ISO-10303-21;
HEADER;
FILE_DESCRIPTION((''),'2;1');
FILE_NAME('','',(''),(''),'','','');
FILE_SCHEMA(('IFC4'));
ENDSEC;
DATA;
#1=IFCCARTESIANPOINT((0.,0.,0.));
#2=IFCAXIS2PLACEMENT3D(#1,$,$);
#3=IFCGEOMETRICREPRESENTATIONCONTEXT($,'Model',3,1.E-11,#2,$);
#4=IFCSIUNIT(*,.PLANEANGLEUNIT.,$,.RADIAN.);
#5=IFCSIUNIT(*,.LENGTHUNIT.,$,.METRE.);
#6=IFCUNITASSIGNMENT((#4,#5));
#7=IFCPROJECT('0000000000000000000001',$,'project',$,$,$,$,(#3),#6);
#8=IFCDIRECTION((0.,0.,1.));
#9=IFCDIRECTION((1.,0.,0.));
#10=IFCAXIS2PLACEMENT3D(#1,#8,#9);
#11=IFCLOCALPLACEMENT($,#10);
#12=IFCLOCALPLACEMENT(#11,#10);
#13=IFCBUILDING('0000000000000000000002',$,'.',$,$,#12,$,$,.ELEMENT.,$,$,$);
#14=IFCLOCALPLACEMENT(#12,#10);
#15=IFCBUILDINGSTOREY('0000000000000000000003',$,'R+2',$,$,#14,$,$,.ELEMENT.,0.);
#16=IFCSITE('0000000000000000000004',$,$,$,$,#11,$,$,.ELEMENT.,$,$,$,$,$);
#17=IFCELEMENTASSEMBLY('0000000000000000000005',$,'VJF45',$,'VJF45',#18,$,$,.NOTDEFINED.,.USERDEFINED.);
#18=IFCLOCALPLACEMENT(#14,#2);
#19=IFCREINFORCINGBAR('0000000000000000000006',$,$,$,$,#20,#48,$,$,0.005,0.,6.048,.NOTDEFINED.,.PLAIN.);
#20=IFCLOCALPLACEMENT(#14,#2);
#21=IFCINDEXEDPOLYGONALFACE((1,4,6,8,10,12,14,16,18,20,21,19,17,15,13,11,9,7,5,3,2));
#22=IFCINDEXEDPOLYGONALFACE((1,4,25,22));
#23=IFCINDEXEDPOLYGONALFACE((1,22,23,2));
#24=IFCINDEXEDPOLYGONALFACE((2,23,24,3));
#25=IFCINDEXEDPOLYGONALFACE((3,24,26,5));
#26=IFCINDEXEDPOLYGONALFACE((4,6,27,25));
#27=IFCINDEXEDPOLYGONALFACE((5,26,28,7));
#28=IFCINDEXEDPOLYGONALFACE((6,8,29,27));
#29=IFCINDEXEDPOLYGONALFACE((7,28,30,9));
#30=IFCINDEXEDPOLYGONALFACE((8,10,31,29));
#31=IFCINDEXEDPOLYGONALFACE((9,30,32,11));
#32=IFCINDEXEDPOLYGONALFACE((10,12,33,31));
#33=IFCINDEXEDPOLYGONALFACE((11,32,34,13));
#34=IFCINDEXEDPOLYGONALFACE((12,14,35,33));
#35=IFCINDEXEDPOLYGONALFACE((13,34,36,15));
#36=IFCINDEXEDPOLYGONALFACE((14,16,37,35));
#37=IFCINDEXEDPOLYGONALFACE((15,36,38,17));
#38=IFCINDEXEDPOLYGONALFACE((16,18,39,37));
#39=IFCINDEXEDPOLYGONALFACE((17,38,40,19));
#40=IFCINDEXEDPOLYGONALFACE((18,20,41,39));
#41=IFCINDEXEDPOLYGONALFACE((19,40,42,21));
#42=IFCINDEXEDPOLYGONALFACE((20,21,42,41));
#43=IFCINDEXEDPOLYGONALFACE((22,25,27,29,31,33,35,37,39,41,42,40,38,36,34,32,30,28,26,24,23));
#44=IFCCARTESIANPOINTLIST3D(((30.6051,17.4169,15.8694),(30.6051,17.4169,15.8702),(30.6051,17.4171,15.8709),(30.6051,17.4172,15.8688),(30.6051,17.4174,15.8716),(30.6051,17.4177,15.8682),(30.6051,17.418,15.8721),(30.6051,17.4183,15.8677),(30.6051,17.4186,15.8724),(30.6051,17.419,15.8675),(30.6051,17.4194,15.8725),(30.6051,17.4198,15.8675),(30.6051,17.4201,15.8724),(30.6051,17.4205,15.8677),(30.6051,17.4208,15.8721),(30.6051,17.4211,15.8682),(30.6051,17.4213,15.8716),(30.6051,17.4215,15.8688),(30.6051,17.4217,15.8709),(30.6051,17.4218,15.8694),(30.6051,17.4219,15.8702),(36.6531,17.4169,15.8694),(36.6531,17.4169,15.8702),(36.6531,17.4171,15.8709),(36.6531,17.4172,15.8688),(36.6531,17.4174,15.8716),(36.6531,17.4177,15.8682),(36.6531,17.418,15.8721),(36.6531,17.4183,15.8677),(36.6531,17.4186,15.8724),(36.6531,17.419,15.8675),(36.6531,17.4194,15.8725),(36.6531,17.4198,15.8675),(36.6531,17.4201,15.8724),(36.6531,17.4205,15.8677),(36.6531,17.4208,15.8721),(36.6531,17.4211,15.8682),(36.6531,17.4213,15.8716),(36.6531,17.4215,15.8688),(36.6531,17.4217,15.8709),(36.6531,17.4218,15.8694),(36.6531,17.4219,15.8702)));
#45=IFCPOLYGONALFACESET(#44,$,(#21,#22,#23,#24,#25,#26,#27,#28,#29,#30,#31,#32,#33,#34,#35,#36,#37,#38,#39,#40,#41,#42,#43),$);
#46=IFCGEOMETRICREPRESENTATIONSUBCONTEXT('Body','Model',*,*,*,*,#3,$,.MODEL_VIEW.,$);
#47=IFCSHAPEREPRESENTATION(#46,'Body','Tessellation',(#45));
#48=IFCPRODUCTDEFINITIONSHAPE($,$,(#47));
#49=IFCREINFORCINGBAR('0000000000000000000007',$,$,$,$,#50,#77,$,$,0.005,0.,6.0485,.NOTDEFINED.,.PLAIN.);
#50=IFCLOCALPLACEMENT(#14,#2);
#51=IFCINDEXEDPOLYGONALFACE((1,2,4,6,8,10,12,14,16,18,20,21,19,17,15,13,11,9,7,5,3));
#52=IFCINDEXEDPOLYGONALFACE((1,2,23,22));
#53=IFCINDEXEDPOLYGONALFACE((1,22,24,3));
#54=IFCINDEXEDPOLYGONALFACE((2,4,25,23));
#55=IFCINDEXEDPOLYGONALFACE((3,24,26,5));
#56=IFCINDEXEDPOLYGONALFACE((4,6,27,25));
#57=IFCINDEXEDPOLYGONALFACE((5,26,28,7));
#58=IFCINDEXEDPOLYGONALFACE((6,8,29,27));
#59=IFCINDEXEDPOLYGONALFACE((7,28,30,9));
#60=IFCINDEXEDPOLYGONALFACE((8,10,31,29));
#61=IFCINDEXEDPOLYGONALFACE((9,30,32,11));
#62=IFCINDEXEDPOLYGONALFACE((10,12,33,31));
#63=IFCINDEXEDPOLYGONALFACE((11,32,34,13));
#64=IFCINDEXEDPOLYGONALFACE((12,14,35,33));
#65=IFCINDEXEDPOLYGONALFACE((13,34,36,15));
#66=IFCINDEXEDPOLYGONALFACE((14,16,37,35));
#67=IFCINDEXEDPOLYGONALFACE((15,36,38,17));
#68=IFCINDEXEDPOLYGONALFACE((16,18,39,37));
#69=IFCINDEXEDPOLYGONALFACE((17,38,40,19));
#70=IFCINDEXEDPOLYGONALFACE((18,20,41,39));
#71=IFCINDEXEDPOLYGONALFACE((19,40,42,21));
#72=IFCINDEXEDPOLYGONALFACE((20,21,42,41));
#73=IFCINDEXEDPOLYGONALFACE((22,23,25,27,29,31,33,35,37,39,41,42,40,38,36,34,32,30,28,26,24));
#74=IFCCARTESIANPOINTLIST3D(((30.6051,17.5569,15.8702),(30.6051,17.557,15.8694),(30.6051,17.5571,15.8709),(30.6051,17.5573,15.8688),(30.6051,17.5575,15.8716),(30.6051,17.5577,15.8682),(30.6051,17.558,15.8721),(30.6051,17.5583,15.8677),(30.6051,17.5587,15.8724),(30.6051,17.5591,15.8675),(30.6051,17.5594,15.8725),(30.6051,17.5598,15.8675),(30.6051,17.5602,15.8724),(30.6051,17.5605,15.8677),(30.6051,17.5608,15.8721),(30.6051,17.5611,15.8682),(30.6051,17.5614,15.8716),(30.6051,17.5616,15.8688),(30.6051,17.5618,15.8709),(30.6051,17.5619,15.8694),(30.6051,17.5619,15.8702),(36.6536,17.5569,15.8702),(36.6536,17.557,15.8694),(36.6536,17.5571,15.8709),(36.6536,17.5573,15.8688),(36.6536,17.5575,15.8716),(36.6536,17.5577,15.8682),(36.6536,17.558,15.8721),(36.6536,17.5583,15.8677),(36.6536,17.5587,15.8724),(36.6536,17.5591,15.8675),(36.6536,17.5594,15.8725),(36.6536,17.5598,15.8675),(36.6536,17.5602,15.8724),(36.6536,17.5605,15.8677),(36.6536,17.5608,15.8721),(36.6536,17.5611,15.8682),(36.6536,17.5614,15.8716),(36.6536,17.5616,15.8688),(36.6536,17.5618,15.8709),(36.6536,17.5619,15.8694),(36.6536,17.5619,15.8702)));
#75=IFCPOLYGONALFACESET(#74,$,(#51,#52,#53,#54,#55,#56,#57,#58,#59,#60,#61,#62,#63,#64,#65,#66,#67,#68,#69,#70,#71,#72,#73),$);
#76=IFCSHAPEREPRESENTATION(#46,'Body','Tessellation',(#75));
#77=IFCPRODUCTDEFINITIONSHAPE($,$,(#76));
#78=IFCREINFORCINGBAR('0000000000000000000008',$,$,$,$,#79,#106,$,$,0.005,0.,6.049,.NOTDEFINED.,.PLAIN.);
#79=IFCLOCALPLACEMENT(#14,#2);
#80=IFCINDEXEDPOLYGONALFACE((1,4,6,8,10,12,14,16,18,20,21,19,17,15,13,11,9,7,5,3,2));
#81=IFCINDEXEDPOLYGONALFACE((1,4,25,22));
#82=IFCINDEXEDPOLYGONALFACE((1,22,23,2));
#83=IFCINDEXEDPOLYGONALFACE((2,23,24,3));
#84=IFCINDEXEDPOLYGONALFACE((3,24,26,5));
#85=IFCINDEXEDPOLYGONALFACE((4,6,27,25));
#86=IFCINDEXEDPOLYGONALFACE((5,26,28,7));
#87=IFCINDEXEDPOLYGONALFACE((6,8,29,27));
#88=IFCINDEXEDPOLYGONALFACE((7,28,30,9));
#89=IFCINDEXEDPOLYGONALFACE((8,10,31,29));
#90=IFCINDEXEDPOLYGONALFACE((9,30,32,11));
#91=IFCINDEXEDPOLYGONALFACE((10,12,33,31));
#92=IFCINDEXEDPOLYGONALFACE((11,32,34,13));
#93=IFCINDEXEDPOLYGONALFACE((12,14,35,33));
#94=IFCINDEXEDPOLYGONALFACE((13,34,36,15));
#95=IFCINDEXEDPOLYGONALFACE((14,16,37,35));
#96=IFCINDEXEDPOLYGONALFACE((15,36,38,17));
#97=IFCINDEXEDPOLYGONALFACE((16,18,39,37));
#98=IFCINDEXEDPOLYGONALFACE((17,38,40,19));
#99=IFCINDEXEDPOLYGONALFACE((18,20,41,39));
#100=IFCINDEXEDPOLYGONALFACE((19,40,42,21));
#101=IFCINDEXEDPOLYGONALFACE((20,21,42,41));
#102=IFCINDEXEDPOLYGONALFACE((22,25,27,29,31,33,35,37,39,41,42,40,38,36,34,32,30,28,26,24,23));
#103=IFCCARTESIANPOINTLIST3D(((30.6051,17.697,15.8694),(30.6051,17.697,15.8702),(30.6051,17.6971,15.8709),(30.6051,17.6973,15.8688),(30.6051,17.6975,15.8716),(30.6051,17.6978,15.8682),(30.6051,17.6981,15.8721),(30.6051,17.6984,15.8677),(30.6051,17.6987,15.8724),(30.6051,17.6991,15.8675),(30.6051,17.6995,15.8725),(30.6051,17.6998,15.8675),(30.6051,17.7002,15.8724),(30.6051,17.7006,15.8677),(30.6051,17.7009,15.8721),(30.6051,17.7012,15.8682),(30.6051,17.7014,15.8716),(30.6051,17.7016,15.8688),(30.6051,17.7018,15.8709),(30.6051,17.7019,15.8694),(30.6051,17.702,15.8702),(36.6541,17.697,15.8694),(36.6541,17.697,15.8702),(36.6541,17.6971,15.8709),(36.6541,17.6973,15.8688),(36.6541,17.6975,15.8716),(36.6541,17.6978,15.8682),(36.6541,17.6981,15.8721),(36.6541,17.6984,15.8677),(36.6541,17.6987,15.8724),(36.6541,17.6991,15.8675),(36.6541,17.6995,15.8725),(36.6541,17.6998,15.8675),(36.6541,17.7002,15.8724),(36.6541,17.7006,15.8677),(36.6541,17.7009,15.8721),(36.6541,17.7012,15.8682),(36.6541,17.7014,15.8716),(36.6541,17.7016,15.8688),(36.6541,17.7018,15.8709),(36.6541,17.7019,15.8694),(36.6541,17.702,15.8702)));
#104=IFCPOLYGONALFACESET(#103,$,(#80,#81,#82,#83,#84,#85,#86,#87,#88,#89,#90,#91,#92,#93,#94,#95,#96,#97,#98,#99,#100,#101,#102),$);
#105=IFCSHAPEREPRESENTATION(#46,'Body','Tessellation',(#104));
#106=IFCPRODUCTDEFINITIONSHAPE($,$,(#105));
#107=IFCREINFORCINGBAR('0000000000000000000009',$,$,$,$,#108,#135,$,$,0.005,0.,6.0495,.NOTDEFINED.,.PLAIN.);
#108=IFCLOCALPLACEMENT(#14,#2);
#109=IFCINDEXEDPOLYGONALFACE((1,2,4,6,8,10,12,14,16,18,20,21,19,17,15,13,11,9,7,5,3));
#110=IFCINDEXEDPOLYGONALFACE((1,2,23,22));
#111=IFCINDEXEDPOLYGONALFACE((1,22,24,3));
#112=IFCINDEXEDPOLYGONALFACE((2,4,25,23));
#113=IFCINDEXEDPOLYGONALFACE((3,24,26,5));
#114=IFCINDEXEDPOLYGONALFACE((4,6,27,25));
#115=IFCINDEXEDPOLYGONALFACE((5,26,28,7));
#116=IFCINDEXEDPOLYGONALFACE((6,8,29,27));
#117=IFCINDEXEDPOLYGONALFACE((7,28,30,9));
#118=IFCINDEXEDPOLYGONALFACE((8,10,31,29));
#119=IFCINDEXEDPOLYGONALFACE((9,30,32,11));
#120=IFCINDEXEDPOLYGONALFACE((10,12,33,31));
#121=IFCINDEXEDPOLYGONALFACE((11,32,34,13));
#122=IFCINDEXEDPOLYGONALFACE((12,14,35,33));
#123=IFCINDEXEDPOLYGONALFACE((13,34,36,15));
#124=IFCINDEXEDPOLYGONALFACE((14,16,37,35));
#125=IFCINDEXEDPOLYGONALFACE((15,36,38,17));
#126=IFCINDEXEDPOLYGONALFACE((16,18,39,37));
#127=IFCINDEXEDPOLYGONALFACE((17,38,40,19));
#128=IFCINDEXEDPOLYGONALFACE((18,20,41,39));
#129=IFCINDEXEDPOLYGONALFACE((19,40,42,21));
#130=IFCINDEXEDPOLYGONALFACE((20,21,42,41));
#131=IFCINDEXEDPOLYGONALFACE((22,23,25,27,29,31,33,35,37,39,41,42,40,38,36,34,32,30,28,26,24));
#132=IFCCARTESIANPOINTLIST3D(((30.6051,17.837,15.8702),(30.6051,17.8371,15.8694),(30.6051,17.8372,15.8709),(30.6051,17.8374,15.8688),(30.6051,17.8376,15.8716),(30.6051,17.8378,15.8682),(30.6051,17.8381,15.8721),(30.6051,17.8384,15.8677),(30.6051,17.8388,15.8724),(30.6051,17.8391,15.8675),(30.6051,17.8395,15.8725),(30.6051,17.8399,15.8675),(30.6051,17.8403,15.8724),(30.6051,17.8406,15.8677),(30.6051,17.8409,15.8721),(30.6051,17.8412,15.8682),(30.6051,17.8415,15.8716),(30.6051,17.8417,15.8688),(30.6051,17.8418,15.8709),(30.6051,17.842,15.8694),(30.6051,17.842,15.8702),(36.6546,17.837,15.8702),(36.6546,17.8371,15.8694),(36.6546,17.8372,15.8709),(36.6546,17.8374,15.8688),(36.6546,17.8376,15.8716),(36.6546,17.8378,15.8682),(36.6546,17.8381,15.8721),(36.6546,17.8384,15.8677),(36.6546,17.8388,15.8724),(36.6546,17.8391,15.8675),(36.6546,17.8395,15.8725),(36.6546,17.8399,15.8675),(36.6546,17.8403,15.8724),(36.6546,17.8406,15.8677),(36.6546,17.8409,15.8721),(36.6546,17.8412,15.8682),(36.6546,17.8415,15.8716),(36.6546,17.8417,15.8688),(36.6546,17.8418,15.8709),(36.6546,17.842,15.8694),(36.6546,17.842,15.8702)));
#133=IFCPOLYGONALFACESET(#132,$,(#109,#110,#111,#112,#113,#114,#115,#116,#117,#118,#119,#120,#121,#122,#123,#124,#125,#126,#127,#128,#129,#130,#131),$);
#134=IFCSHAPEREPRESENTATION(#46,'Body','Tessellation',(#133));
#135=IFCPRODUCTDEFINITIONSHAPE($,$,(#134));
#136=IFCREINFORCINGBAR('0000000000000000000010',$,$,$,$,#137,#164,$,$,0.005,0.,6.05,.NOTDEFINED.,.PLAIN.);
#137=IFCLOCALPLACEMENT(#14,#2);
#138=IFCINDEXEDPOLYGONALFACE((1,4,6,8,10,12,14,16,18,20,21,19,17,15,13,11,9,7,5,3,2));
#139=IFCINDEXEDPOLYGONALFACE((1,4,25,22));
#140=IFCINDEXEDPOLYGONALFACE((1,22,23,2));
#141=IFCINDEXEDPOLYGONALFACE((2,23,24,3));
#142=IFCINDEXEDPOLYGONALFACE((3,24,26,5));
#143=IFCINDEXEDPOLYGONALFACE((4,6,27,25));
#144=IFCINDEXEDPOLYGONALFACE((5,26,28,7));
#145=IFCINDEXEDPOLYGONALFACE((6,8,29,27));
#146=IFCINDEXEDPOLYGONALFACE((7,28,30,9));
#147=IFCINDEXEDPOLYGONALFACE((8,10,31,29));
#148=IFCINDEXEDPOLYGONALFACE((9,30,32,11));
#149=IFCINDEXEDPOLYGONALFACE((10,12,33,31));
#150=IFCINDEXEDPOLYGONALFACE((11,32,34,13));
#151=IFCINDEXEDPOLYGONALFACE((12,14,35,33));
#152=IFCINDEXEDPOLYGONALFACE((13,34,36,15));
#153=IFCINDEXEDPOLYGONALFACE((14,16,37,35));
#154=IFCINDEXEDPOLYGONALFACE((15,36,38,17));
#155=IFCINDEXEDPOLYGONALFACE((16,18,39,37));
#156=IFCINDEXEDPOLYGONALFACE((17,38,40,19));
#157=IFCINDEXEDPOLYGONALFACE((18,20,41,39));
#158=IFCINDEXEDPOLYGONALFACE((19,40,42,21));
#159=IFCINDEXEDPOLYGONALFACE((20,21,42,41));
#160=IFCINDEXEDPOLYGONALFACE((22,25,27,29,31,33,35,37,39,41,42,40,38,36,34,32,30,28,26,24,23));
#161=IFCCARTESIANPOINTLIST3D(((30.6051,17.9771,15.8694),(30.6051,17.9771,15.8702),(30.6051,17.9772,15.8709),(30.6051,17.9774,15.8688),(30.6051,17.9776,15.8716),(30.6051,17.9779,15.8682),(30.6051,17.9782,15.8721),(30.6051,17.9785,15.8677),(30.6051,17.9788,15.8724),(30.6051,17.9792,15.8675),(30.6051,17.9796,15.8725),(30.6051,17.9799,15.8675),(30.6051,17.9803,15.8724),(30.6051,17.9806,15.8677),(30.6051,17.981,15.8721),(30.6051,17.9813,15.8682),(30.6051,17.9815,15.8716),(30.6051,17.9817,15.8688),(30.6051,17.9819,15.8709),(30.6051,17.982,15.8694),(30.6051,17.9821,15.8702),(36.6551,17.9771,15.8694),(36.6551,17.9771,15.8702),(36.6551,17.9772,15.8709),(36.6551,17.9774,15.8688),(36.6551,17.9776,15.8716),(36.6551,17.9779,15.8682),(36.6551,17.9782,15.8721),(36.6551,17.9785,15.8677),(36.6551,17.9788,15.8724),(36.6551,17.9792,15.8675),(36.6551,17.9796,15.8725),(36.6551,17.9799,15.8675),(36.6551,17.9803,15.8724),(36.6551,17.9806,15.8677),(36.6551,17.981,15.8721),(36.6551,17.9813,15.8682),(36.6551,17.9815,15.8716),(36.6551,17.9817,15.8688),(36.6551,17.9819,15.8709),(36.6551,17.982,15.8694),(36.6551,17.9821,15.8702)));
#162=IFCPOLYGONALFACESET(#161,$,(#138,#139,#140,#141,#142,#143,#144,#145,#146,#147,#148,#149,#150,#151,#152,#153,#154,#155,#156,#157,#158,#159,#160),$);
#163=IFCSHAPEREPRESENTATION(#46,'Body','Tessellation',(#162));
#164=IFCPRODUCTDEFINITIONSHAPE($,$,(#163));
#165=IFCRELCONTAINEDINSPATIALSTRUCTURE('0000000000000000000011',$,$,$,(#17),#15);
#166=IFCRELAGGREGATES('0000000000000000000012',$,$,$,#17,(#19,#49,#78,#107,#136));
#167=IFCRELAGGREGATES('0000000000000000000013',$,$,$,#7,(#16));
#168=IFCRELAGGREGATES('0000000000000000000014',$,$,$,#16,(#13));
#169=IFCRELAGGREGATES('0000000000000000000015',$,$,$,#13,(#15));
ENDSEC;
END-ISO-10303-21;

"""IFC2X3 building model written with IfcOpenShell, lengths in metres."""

from ifc_helpers import new_model, entity, si_unit, origin, origin_with_axes, place, context, subcontext, project, spatial, shape, element, aggregate, save


model = new_model("IFC2X3")

# Units and contexts
model_context = context("Model", 3, precision=1e-11, world=origin())
body_context = subcontext(model_context, "Body", "Model", "MODEL_VIEW")
ifc_project = project(units=[si_unit("PLANEANGLEUNIT", "RADIAN"), si_unit("LENGTHUNIT", "METRE")], contexts=[model_context])

# Site, building, storey
site_placement = place(None, origin_with_axes())
site = spatial("IfcSite", under=ifc_project, at=site_placement, CompositionType="ELEMENT")
building_placement = place(site_placement, origin_with_axes())
building = spatial("IfcBuilding", under=site, at=building_placement, Name=".", CompositionType="ELEMENT")
storey_placement = place(building_placement, origin_with_axes())
storey = spatial("IfcBuildingStorey", under=building, at=storey_placement, Name="R+2", CompositionType="ELEMENT", Elevation=0.0)

# Element assembly, reinforcing bars
assembly_1_placement = place(storey_placement, origin_with_axes())
assembly_1 = element("IfcElementAssembly", 1, at=assembly_1_placement, inside=storey, Name="VJF45", ObjectType="VJF45", AssemblyPlace="NOTDEFINED", PredefinedType="USERDEFINED")
reinforcing_bar_1_placement = place(assembly_1_placement, origin_with_axes())
reinforcing_bar_1 = element("IfcReinforcingBar", 2, at=reinforcing_bar_1_placement, BarLength=6.048, BarRole="NOTDEFINED", BarSurface="PLAIN", CrossSectionArea=0.0, NominalDiameter=0.005, shapes=[
    shape(body_context, "Body", "AdvancedSweptSolid", [entity("IfcSweptDiskSolid", entity("IfcPolyline", [entity("IfcCartesianPoint", [30.6051, 17.4194, 15.87]), entity("IfcCartesianPoint", [36.6531, 17.4194, 15.87])]), 0.0025, None, 0.0, 6.048)]),
    shape(body_context, "Body", "AdvancedSweptSolid", [entity("IfcSweptDiskSolid", entity("IfcPolyline", [entity("IfcCartesianPoint", [30.6051, 17.4194, 15.87]), entity("IfcCartesianPoint", [36.6531, 17.4194, 15.87])]), 0.0025, None, 0.0, 6.048)]),
])
reinforcing_bar_2_placement = place(assembly_1_placement, origin_with_axes())
reinforcing_bar_2 = element("IfcReinforcingBar", 3, at=reinforcing_bar_2_placement, BarLength=6.0485, BarRole="NOTDEFINED", BarSurface="PLAIN", CrossSectionArea=0.0, NominalDiameter=0.005, shapes=[
    shape(body_context, "Body", "AdvancedSweptSolid", [entity("IfcSweptDiskSolid", entity("IfcPolyline", [entity("IfcCartesianPoint", [30.6051, 17.5594, 15.87]), entity("IfcCartesianPoint", [36.6536, 17.5594, 15.87])]), 0.0025, None, 0.0, 6.0485)]),
    shape(body_context, "Body", "AdvancedSweptSolid", [entity("IfcSweptDiskSolid", entity("IfcPolyline", [entity("IfcCartesianPoint", [30.6051, 17.5594, 15.87]), entity("IfcCartesianPoint", [36.6536, 17.5594, 15.87])]), 0.0025, None, 0.0, 6.0485)]),
])
reinforcing_bar_3_placement = place(assembly_1_placement, origin_with_axes())
reinforcing_bar_3 = element("IfcReinforcingBar", 4, at=reinforcing_bar_3_placement, BarLength=6.049, BarRole="NOTDEFINED", BarSurface="PLAIN", CrossSectionArea=0.0, NominalDiameter=0.005, shapes=[
    shape(body_context, "Body", "AdvancedSweptSolid", [entity("IfcSweptDiskSolid", entity("IfcPolyline", [entity("IfcCartesianPoint", [30.6051, 17.6995, 15.87]), entity("IfcCartesianPoint", [36.6541, 17.6995, 15.87])]), 0.0025, None, 0.0, 6.049)]),
    shape(body_context, "Body", "AdvancedSweptSolid", [entity("IfcSweptDiskSolid", entity("IfcPolyline", [entity("IfcCartesianPoint", [30.6051, 17.6995, 15.87]), entity("IfcCartesianPoint", [36.6541, 17.6995, 15.87])]), 0.0025, None, 0.0, 6.049)]),
])
reinforcing_bar_4_placement = place(assembly_1_placement, origin_with_axes())
reinforcing_bar_4 = element("IfcReinforcingBar", 5, at=reinforcing_bar_4_placement, BarLength=6.0495, BarRole="NOTDEFINED", BarSurface="PLAIN", CrossSectionArea=0.0, NominalDiameter=0.005, shapes=[
    shape(body_context, "Body", "AdvancedSweptSolid", [entity("IfcSweptDiskSolid", entity("IfcPolyline", [entity("IfcCartesianPoint", [30.6051, 17.8395, 15.87]), entity("IfcCartesianPoint", [36.6546, 17.8395, 15.87])]), 0.0025, None, 0.0, 6.0495)]),
    shape(body_context, "Body", "AdvancedSweptSolid", [entity("IfcSweptDiskSolid", entity("IfcPolyline", [entity("IfcCartesianPoint", [30.6051, 17.8395, 15.87]), entity("IfcCartesianPoint", [36.6546, 17.8395, 15.87])]), 0.0025, None, 0.0, 6.0495)]),
])
reinforcing_bar_5_placement = place(assembly_1_placement, origin_with_axes())
reinforcing_bar_5 = element("IfcReinforcingBar", 6, at=reinforcing_bar_5_placement, BarLength=6.05, BarRole="NOTDEFINED", BarSurface="PLAIN", CrossSectionArea=0.0, NominalDiameter=0.005, shapes=[
    shape(body_context, "Body", "AdvancedSweptSolid", [entity("IfcSweptDiskSolid", entity("IfcPolyline", [entity("IfcCartesianPoint", [30.6051, 17.9796, 15.87]), entity("IfcCartesianPoint", [36.6551, 17.9796, 15.87])]), 0.0025, None, 0.0, 6.05)]),
    shape(body_context, "Body", "AdvancedSweptSolid", [entity("IfcSweptDiskSolid", entity("IfcPolyline", [entity("IfcCartesianPoint", [30.6051, 17.9796, 15.87]), entity("IfcCartesianPoint", [36.6551, 17.9796, 15.87])]), 0.0025, None, 0.0, 6.05)]),
])
aggregate(assembly_1, [reinforcing_bar_1, reinforcing_bar_2, reinforcing_bar_3, reinforcing_bar_4, reinforcing_bar_5])

save(model, "model.ifc")
